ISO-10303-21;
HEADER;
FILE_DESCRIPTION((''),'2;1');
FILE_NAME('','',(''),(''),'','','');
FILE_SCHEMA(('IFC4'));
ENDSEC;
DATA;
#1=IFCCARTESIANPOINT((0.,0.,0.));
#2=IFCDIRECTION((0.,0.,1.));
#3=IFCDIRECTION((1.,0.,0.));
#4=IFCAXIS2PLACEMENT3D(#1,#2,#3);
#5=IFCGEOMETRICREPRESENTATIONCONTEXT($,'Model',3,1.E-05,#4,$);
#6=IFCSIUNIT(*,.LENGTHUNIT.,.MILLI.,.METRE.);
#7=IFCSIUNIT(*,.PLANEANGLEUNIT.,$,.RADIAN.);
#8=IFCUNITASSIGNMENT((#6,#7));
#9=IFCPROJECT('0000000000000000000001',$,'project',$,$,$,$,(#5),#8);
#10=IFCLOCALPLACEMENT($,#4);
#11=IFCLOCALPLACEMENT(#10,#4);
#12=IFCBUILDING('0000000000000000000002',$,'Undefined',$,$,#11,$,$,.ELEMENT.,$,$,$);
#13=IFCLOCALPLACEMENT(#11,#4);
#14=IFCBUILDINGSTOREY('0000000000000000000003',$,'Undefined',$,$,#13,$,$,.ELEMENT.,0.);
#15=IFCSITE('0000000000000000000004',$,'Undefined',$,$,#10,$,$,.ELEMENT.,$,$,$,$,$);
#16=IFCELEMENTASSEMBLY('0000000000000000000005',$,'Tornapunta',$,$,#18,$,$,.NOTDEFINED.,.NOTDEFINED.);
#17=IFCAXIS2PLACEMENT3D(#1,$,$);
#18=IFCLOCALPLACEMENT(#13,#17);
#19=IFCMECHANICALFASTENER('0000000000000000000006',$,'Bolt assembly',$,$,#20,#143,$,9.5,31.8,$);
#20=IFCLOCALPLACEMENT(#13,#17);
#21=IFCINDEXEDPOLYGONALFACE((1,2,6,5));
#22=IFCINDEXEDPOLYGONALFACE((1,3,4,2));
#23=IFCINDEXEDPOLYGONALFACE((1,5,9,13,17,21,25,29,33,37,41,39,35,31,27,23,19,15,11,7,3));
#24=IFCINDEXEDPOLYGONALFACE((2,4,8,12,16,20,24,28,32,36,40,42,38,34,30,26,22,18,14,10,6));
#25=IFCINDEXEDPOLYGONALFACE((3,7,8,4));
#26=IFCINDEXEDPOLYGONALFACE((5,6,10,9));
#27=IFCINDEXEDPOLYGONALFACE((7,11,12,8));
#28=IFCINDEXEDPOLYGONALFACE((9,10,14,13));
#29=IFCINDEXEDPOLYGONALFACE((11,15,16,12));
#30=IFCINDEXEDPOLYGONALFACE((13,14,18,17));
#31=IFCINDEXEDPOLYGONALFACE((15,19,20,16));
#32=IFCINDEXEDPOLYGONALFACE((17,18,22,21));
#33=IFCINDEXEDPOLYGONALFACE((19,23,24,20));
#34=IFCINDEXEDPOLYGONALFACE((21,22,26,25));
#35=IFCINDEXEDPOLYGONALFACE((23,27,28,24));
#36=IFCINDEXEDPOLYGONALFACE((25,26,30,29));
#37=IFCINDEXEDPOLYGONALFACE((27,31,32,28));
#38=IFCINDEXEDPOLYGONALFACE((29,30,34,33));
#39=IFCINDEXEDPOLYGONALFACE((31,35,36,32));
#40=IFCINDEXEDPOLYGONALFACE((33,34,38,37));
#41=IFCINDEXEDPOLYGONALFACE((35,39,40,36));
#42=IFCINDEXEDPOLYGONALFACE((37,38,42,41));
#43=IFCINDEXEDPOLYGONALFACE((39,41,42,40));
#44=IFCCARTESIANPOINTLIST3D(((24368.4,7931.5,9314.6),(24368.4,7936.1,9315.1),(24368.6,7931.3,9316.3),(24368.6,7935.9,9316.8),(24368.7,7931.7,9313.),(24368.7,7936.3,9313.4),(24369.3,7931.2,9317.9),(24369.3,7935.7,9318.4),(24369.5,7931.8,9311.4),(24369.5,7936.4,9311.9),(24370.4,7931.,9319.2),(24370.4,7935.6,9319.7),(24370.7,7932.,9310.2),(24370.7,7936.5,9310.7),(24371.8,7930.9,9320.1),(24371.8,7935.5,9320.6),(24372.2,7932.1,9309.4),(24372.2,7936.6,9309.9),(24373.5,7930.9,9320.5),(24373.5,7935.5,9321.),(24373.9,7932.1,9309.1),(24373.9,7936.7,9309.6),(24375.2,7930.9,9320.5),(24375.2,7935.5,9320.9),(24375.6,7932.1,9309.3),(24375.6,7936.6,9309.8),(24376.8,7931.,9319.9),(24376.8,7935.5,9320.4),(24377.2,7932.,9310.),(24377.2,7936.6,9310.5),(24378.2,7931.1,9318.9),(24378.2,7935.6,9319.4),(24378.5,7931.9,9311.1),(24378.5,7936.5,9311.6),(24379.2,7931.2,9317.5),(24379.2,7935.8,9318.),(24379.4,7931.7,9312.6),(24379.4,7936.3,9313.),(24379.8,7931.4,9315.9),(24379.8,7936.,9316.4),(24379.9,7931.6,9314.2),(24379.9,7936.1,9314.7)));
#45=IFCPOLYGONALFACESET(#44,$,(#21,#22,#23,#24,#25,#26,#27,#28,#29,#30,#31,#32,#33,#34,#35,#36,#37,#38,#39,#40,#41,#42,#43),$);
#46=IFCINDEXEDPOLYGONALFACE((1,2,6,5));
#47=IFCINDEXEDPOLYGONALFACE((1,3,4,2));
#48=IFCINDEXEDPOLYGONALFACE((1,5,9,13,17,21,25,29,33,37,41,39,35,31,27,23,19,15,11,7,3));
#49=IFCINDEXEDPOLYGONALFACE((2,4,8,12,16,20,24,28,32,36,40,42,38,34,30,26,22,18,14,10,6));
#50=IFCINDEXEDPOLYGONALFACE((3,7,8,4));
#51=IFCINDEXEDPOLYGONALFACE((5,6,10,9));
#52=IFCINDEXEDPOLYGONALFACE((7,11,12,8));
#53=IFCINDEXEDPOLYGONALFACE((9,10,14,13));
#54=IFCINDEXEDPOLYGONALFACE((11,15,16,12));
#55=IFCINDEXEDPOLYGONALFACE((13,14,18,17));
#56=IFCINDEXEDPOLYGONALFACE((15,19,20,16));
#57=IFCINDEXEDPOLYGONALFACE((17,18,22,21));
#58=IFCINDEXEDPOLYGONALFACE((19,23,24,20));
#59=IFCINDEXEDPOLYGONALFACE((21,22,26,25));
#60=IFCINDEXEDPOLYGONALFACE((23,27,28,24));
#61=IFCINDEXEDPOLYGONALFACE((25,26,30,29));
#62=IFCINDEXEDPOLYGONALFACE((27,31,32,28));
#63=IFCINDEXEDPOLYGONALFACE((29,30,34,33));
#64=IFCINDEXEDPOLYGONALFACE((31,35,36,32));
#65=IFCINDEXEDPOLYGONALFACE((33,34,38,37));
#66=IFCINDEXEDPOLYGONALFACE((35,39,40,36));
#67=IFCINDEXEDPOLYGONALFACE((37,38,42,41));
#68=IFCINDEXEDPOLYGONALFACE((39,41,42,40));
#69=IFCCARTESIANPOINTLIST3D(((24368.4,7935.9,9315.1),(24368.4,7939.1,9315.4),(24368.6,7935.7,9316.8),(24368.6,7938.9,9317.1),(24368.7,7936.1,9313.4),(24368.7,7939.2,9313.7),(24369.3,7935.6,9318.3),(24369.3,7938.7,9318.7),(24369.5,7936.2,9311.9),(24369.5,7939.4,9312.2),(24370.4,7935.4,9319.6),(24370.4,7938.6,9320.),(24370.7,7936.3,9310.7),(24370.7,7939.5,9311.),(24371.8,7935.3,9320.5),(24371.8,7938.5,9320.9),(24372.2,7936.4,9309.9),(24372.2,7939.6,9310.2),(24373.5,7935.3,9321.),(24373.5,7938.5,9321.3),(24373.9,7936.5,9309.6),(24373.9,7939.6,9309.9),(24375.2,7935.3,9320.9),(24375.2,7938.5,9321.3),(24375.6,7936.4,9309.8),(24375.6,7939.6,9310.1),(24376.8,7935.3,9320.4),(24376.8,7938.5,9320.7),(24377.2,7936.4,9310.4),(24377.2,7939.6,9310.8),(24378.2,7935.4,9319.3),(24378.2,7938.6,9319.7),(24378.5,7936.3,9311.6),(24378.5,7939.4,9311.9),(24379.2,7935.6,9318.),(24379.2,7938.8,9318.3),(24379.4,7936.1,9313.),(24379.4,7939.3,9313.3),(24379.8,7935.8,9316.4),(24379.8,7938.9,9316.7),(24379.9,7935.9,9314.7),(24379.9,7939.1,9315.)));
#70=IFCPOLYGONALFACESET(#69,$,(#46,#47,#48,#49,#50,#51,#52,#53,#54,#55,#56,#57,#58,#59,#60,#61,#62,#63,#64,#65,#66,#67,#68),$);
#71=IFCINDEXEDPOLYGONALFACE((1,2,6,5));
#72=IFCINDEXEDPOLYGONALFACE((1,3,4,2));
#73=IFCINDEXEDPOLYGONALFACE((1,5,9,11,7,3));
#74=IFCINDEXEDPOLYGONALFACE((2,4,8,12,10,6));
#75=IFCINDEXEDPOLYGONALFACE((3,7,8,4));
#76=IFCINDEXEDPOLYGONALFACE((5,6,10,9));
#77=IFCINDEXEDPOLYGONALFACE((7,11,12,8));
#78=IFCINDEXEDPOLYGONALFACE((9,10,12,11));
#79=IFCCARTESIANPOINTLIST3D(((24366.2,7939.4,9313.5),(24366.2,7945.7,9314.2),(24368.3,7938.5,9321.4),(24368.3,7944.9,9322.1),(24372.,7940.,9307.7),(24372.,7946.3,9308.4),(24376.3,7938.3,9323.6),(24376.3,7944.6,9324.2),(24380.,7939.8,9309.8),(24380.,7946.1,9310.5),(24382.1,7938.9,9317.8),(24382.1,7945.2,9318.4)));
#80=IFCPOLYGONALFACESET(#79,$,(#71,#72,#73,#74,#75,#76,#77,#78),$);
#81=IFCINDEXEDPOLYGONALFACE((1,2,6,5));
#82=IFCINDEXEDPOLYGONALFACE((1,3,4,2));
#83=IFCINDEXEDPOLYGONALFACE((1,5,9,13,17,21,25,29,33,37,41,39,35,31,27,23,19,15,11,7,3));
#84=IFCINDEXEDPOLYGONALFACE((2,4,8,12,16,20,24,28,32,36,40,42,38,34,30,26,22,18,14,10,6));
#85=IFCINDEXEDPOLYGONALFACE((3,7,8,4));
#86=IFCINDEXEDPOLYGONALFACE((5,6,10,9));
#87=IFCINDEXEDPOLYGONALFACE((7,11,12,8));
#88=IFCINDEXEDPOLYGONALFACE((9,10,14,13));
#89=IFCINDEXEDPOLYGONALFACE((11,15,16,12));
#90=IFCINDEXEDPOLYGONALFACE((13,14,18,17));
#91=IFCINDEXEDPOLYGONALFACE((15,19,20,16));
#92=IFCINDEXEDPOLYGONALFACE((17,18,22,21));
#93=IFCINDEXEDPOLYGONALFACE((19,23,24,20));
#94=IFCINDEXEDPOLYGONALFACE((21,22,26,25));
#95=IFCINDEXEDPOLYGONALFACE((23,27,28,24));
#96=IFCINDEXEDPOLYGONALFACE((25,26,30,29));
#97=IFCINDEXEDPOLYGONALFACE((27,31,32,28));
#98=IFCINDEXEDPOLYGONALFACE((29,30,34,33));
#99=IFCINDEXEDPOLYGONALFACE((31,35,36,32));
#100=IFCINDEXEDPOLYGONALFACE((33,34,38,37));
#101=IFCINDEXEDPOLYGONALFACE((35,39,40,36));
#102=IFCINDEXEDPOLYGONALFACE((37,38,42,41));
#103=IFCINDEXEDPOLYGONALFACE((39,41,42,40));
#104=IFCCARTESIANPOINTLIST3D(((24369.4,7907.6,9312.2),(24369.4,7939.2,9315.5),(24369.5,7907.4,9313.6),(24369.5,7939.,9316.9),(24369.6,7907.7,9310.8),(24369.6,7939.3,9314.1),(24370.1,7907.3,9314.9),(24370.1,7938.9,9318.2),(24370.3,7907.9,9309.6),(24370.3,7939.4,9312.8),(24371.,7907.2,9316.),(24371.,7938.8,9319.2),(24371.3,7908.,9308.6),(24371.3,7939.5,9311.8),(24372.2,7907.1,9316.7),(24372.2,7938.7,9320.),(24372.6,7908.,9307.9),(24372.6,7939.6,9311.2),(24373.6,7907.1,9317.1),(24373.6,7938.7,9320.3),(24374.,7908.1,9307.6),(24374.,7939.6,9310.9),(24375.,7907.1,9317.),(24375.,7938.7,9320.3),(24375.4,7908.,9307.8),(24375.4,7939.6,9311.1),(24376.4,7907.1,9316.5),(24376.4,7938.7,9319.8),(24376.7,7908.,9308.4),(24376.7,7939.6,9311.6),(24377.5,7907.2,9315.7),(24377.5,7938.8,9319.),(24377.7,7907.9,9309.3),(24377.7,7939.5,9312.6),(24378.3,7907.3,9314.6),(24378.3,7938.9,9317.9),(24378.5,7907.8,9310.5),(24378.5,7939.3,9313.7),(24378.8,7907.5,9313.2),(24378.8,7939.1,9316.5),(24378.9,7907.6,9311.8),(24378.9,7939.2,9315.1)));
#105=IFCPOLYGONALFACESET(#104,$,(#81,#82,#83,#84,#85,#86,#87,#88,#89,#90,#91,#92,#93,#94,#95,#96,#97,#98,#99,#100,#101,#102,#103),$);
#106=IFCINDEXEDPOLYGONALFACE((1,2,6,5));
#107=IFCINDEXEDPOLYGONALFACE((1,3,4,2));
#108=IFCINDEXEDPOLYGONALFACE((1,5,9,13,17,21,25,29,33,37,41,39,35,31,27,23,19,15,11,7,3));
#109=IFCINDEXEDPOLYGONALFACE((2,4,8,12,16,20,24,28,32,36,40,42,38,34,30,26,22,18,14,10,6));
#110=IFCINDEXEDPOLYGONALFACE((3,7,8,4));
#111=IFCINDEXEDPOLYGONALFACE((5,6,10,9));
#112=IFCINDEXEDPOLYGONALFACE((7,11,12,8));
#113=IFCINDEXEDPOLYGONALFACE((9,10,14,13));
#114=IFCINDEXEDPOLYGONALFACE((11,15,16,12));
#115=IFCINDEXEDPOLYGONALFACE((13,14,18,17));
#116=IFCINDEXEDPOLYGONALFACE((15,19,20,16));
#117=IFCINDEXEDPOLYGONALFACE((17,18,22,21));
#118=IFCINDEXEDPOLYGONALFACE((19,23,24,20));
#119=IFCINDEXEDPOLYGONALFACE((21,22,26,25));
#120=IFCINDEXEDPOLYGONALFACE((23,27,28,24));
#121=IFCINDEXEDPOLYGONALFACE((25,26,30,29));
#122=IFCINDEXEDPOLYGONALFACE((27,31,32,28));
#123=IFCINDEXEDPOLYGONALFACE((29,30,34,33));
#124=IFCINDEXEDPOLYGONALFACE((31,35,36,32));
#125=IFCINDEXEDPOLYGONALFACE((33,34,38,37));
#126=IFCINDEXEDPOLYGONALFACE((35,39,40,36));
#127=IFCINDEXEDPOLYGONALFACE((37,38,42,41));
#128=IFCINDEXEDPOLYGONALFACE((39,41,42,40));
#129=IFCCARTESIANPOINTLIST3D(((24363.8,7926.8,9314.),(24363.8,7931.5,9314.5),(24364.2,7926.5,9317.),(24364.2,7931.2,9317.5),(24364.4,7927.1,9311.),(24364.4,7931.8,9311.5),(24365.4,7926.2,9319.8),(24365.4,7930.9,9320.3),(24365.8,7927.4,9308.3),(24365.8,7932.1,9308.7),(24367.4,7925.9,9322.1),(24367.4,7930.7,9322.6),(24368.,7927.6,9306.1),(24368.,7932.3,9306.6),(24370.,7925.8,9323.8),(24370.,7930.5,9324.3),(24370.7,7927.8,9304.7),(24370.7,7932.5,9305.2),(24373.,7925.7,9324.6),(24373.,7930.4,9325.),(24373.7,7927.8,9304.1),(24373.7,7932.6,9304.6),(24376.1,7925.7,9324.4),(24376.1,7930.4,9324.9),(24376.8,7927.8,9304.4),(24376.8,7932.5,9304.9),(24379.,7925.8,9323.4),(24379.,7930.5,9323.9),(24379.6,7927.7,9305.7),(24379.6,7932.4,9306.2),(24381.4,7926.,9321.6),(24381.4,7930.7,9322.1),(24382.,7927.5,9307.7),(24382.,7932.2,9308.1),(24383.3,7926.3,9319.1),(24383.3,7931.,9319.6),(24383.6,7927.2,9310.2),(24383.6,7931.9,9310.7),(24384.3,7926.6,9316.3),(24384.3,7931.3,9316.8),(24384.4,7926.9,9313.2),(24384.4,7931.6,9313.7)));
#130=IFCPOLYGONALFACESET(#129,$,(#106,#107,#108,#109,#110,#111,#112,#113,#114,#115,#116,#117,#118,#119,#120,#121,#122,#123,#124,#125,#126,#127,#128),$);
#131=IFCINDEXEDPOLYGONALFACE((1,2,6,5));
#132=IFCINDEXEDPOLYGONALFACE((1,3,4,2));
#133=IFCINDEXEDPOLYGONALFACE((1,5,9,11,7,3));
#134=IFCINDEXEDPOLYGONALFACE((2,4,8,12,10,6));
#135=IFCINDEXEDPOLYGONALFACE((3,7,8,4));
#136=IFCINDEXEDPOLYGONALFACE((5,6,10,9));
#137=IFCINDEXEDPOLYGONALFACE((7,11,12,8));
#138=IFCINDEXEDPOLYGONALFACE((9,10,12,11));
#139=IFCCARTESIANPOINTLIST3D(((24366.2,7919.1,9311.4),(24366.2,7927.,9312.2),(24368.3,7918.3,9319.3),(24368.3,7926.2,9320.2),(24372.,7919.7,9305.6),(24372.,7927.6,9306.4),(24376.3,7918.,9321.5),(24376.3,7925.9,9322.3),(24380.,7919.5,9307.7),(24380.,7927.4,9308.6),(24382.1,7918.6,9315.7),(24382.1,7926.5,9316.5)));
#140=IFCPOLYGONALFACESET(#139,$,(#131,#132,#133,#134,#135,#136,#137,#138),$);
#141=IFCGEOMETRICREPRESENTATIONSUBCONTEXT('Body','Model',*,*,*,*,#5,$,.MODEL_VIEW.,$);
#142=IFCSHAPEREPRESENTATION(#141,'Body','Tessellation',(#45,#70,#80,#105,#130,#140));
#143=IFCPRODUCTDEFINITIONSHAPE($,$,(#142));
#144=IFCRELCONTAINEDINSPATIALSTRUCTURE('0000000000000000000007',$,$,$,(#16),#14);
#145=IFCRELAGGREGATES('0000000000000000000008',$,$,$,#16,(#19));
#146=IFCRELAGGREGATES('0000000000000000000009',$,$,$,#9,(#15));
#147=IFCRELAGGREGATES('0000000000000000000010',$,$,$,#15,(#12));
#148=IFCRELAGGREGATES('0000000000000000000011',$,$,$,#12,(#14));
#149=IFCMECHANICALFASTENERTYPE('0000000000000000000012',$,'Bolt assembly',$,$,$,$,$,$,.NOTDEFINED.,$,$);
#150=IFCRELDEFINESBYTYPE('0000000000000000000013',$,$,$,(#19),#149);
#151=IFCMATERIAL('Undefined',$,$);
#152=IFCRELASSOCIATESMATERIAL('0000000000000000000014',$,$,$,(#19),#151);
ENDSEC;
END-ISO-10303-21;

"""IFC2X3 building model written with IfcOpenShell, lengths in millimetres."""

from ifc_helpers import new_model, si_unit, frame, origin_with_axes, origin_2d_with_axis, place, context, subcontext, project, spatial, polyline, circle, outline, extrude, source, transform, mapped, material, type_object, element, aggregate, save


model = new_model("IFC2X3")

# Units and contexts
model_context = context("Model", 3, precision=1e-05, world=origin_with_axes())
body_context = subcontext(model_context, "Body", "Model", "MODEL_VIEW")
ifc_project = project(units=[si_unit("LENGTHUNIT", "METRE", prefix="MILLI"), si_unit("PLANEANGLEUNIT", "RADIAN")], contexts=[model_context])

# Site, building, storey
site_placement = place(None, origin_with_axes())
site = spatial("IfcSite", under=ifc_project, at=site_placement, Name="Undefined", CompositionType="ELEMENT")
building_placement = place(site_placement, origin_with_axes())
building = spatial("IfcBuilding", under=site, at=building_placement, Name="Undefined", CompositionType="ELEMENT")
storey_placement = place(building_placement, origin_with_axes())
storey = spatial("IfcBuildingStorey", under=building, at=storey_placement, Name="Undefined", CompositionType="ELEMENT", Elevation=0.0)

# Shared definitions
ifc_material_1 = material(Name="Undefined")
mechanical_fastener_type = type_object("IfcMechanicalFastenerType", Name="Bolt assembly")

# Element assembly
assembly_1_placement = place(storey_placement, origin_with_axes())
assembly_1 = element("IfcElementAssembly", 1, at=assembly_1_placement, inside=storey, Name="Tornapunta", AssemblyPlace="NOTDEFINED", PredefinedType="NOTDEFINED")

# Mechanical fastener
shared_shape_1 = source(origin_with_axes(), body_context, "Body", "SweptSolid", [
    extrude(circle(Radius=5.8, at=origin_2d_with_axis()), frame((0.0, -0.1, 0.0), z_axis=(0.0, 1.0, 0.0), x_axis=(1.0, 0.0, 0.0)), (0.0, 0.0, 1.0), 4.6),
    extrude(circle(Radius=5.8, at=origin_2d_with_axis()), frame((0.0, -3.1, 0.0), z_axis=(0.0, 1.0, 0.0), x_axis=(1.0, 0.0, 0.0)), (0.0, 0.0, 1.0), 3.2),
    extrude(outline(polyline([(7.1, -4.1), (7.1, 4.1), (0.0, 8.2), (-7.1, 4.1), (-7.1, -4.1), (0.0, -8.2), (7.1, -4.1)])), frame((0.0, -9.5, 0.0), z_axis=(0.0, 1.0, 0.0), x_axis=(1.0, 0.0, 0.0)), (0.0, 0.0, 1.0), 6.3),
    extrude(circle(Radius=4.8, at=origin_2d_with_axis()), frame((0.0, -3.2, 0.0), z_axis=(0.0, 1.0, 0.0), x_axis=(1.0, 0.0, 0.0)), (0.0, 0.0, 1.0), 31.8),
    extrude(circle(Radius=10.3, at=origin_2d_with_axis()), frame((0.0, 4.5, 0.0), z_axis=(0.0, 1.0, 0.0), x_axis=(1.0, 0.0, 0.0)), (0.0, 0.0, 1.0), 4.8),
    extrude(outline(polyline([(7.1, -4.1), (7.1, 4.1), (0.0, 8.2), (-7.1, 4.1), (-7.1, -4.1), (0.0, -8.2), (7.1, -4.1)])), frame((0.0, 9.3, 0.0), z_axis=(0.0, 1.0, 0.0), x_axis=(1.0, 0.0, 0.0)), (0.0, 0.0, 1.0), 7.9),
])
mechanical_fastener_1_placement = place(assembly_1_placement, frame((24374.1, 7936.0, 9315.3), z_axis=(0.707107, 0.072947, -0.703334), x_axis=(0.707107, -0.072947, 0.703334)))
mechanical_fastener_1 = element("IfcMechanicalFastener", 2, at=mechanical_fastener_1_placement, type_object=mechanical_fastener_type, material=ifc_material_1, Name="Bolt assembly", NominalDiameter=9.5, NominalLength=31.8, context=body_context, shape_type="MappedRepresentation", body=[
    mapped(shared_shape_1, transform((0.0, 0.0, 0.0))),
])
aggregate(assembly_1, [mechanical_fastener_1])

save(model, "model.ifc")
